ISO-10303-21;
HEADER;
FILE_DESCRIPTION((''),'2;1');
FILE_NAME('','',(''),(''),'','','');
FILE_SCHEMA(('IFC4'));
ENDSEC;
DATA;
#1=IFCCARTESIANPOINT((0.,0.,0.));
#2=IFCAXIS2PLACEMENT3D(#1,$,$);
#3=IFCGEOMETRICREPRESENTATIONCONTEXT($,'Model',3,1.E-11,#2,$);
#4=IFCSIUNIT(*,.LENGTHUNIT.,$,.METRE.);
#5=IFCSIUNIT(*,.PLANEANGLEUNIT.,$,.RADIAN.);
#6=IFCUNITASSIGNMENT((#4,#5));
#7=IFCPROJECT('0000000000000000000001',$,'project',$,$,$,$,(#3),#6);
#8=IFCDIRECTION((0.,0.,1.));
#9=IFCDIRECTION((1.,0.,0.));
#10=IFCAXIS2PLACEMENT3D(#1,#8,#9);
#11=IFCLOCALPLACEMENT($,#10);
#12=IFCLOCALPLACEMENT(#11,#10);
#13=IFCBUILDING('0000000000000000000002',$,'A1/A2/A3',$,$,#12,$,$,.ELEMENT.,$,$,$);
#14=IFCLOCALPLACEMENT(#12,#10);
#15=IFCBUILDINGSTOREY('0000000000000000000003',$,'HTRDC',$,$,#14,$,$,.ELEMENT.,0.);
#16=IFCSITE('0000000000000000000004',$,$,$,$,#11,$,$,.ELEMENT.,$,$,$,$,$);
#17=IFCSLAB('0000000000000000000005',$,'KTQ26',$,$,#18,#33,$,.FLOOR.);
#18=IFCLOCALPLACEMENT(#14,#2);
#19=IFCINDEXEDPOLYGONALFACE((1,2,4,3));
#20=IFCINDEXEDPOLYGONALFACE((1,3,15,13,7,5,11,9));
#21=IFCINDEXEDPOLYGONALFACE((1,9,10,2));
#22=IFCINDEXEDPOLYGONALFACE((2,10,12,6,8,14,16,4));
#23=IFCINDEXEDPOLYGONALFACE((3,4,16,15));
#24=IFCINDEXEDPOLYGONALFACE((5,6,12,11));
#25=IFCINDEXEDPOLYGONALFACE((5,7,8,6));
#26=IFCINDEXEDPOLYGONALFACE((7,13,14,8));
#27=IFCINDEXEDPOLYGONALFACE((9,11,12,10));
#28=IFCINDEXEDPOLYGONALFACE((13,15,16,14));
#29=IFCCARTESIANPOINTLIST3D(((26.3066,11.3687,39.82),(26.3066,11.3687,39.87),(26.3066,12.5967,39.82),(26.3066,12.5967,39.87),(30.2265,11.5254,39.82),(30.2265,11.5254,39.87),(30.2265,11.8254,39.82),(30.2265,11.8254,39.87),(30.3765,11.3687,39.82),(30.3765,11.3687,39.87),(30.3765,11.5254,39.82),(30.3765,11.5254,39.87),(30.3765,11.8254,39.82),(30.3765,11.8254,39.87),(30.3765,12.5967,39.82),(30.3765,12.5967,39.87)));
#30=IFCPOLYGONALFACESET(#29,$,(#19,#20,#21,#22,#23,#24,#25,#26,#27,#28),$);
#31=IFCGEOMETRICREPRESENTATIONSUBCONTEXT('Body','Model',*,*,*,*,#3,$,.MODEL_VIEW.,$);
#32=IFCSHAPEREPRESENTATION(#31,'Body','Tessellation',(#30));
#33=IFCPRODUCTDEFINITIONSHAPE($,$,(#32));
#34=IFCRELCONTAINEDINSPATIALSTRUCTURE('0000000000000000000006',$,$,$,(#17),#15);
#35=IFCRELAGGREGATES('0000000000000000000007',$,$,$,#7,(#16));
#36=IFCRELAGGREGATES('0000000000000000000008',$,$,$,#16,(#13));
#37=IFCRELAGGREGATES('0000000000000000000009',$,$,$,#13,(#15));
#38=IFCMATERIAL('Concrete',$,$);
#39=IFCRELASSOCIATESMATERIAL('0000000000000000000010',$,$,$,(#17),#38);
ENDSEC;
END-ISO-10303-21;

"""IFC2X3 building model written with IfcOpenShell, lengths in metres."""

from ifc_helpers import new_model, si_unit, frame, origin, origin_with_axes, place, context, subcontext, project, spatial, polyline, outline, extrude, material, element, save


model = new_model("IFC2X3")

# Units and contexts
model_context = context("Model", 3, precision=1e-11, world=origin())
body_context = subcontext(model_context, "Body", "Model", "MODEL_VIEW")
ifc_project = project(units=[si_unit("LENGTHUNIT", "METRE"), si_unit("PLANEANGLEUNIT", "RADIAN")], contexts=[model_context])

# Site, building, storey
site_placement = place(None, origin_with_axes())
site = spatial("IfcSite", under=ifc_project, at=site_placement, CompositionType="ELEMENT")
building_placement = place(site_placement, origin_with_axes())
building = spatial("IfcBuilding", under=site, at=building_placement, Name="A1/A2/A3", CompositionType="ELEMENT")
storey_placement = place(building_placement, origin_with_axes())
storey = spatial("IfcBuildingStorey", under=building, at=storey_placement, Name="HTRDC", CompositionType="ELEMENT", Elevation=0.0)

# Shared definitions
ifc_material = material(Name="Concrete")

# Slab, opening
slab_1_placement = place(storey_placement, frame((26.3066, 11.3687, 39.82), z_axis=(0.0, 0.0, 1.0), x_axis=(1.0, 0.0, 0.0)))
slab_1 = element("IfcSlab", 1, at=slab_1_placement, inside=storey, material=ifc_material, Name="KTQ26", PredefinedType="FLOOR", context=body_context, shape_type="SweptSolid", body=[
    extrude(outline(polyline([(0.0, 0.0), (0.0, -4.0699), (1.228, -4.0699), (1.228, 0.0), (0.0, 0.0)])), frame((0.0, 0.0, 0.0), z_axis=(0.0, 0.0, 1.0), x_axis=(0.0, 1.0, 0.0)), (0.0, 0.0, 1.0), 0.05),
])
opening_1_placement = place(slab_1_placement, origin_with_axes())
element("IfcOpeningElement", 2, at=opening_1_placement, cuts=slab_1, ObjectType="Opening", context=body_context, shape_type="SweptSolid", body=[
    extrude(outline(polyline([(0.1566, -3.9199), (0.1566, -4.0699), (0.4566, -4.0699), (0.4566, -3.9199), (0.1566, -3.9199)])), frame((0.0, 0.0, 0.0), z_axis=(0.0, 0.0, 1.0), x_axis=(0.0, 1.0, 0.0)), (0.0, 0.0, 1.0), 0.05),
])

save(model, "model.ifc")
